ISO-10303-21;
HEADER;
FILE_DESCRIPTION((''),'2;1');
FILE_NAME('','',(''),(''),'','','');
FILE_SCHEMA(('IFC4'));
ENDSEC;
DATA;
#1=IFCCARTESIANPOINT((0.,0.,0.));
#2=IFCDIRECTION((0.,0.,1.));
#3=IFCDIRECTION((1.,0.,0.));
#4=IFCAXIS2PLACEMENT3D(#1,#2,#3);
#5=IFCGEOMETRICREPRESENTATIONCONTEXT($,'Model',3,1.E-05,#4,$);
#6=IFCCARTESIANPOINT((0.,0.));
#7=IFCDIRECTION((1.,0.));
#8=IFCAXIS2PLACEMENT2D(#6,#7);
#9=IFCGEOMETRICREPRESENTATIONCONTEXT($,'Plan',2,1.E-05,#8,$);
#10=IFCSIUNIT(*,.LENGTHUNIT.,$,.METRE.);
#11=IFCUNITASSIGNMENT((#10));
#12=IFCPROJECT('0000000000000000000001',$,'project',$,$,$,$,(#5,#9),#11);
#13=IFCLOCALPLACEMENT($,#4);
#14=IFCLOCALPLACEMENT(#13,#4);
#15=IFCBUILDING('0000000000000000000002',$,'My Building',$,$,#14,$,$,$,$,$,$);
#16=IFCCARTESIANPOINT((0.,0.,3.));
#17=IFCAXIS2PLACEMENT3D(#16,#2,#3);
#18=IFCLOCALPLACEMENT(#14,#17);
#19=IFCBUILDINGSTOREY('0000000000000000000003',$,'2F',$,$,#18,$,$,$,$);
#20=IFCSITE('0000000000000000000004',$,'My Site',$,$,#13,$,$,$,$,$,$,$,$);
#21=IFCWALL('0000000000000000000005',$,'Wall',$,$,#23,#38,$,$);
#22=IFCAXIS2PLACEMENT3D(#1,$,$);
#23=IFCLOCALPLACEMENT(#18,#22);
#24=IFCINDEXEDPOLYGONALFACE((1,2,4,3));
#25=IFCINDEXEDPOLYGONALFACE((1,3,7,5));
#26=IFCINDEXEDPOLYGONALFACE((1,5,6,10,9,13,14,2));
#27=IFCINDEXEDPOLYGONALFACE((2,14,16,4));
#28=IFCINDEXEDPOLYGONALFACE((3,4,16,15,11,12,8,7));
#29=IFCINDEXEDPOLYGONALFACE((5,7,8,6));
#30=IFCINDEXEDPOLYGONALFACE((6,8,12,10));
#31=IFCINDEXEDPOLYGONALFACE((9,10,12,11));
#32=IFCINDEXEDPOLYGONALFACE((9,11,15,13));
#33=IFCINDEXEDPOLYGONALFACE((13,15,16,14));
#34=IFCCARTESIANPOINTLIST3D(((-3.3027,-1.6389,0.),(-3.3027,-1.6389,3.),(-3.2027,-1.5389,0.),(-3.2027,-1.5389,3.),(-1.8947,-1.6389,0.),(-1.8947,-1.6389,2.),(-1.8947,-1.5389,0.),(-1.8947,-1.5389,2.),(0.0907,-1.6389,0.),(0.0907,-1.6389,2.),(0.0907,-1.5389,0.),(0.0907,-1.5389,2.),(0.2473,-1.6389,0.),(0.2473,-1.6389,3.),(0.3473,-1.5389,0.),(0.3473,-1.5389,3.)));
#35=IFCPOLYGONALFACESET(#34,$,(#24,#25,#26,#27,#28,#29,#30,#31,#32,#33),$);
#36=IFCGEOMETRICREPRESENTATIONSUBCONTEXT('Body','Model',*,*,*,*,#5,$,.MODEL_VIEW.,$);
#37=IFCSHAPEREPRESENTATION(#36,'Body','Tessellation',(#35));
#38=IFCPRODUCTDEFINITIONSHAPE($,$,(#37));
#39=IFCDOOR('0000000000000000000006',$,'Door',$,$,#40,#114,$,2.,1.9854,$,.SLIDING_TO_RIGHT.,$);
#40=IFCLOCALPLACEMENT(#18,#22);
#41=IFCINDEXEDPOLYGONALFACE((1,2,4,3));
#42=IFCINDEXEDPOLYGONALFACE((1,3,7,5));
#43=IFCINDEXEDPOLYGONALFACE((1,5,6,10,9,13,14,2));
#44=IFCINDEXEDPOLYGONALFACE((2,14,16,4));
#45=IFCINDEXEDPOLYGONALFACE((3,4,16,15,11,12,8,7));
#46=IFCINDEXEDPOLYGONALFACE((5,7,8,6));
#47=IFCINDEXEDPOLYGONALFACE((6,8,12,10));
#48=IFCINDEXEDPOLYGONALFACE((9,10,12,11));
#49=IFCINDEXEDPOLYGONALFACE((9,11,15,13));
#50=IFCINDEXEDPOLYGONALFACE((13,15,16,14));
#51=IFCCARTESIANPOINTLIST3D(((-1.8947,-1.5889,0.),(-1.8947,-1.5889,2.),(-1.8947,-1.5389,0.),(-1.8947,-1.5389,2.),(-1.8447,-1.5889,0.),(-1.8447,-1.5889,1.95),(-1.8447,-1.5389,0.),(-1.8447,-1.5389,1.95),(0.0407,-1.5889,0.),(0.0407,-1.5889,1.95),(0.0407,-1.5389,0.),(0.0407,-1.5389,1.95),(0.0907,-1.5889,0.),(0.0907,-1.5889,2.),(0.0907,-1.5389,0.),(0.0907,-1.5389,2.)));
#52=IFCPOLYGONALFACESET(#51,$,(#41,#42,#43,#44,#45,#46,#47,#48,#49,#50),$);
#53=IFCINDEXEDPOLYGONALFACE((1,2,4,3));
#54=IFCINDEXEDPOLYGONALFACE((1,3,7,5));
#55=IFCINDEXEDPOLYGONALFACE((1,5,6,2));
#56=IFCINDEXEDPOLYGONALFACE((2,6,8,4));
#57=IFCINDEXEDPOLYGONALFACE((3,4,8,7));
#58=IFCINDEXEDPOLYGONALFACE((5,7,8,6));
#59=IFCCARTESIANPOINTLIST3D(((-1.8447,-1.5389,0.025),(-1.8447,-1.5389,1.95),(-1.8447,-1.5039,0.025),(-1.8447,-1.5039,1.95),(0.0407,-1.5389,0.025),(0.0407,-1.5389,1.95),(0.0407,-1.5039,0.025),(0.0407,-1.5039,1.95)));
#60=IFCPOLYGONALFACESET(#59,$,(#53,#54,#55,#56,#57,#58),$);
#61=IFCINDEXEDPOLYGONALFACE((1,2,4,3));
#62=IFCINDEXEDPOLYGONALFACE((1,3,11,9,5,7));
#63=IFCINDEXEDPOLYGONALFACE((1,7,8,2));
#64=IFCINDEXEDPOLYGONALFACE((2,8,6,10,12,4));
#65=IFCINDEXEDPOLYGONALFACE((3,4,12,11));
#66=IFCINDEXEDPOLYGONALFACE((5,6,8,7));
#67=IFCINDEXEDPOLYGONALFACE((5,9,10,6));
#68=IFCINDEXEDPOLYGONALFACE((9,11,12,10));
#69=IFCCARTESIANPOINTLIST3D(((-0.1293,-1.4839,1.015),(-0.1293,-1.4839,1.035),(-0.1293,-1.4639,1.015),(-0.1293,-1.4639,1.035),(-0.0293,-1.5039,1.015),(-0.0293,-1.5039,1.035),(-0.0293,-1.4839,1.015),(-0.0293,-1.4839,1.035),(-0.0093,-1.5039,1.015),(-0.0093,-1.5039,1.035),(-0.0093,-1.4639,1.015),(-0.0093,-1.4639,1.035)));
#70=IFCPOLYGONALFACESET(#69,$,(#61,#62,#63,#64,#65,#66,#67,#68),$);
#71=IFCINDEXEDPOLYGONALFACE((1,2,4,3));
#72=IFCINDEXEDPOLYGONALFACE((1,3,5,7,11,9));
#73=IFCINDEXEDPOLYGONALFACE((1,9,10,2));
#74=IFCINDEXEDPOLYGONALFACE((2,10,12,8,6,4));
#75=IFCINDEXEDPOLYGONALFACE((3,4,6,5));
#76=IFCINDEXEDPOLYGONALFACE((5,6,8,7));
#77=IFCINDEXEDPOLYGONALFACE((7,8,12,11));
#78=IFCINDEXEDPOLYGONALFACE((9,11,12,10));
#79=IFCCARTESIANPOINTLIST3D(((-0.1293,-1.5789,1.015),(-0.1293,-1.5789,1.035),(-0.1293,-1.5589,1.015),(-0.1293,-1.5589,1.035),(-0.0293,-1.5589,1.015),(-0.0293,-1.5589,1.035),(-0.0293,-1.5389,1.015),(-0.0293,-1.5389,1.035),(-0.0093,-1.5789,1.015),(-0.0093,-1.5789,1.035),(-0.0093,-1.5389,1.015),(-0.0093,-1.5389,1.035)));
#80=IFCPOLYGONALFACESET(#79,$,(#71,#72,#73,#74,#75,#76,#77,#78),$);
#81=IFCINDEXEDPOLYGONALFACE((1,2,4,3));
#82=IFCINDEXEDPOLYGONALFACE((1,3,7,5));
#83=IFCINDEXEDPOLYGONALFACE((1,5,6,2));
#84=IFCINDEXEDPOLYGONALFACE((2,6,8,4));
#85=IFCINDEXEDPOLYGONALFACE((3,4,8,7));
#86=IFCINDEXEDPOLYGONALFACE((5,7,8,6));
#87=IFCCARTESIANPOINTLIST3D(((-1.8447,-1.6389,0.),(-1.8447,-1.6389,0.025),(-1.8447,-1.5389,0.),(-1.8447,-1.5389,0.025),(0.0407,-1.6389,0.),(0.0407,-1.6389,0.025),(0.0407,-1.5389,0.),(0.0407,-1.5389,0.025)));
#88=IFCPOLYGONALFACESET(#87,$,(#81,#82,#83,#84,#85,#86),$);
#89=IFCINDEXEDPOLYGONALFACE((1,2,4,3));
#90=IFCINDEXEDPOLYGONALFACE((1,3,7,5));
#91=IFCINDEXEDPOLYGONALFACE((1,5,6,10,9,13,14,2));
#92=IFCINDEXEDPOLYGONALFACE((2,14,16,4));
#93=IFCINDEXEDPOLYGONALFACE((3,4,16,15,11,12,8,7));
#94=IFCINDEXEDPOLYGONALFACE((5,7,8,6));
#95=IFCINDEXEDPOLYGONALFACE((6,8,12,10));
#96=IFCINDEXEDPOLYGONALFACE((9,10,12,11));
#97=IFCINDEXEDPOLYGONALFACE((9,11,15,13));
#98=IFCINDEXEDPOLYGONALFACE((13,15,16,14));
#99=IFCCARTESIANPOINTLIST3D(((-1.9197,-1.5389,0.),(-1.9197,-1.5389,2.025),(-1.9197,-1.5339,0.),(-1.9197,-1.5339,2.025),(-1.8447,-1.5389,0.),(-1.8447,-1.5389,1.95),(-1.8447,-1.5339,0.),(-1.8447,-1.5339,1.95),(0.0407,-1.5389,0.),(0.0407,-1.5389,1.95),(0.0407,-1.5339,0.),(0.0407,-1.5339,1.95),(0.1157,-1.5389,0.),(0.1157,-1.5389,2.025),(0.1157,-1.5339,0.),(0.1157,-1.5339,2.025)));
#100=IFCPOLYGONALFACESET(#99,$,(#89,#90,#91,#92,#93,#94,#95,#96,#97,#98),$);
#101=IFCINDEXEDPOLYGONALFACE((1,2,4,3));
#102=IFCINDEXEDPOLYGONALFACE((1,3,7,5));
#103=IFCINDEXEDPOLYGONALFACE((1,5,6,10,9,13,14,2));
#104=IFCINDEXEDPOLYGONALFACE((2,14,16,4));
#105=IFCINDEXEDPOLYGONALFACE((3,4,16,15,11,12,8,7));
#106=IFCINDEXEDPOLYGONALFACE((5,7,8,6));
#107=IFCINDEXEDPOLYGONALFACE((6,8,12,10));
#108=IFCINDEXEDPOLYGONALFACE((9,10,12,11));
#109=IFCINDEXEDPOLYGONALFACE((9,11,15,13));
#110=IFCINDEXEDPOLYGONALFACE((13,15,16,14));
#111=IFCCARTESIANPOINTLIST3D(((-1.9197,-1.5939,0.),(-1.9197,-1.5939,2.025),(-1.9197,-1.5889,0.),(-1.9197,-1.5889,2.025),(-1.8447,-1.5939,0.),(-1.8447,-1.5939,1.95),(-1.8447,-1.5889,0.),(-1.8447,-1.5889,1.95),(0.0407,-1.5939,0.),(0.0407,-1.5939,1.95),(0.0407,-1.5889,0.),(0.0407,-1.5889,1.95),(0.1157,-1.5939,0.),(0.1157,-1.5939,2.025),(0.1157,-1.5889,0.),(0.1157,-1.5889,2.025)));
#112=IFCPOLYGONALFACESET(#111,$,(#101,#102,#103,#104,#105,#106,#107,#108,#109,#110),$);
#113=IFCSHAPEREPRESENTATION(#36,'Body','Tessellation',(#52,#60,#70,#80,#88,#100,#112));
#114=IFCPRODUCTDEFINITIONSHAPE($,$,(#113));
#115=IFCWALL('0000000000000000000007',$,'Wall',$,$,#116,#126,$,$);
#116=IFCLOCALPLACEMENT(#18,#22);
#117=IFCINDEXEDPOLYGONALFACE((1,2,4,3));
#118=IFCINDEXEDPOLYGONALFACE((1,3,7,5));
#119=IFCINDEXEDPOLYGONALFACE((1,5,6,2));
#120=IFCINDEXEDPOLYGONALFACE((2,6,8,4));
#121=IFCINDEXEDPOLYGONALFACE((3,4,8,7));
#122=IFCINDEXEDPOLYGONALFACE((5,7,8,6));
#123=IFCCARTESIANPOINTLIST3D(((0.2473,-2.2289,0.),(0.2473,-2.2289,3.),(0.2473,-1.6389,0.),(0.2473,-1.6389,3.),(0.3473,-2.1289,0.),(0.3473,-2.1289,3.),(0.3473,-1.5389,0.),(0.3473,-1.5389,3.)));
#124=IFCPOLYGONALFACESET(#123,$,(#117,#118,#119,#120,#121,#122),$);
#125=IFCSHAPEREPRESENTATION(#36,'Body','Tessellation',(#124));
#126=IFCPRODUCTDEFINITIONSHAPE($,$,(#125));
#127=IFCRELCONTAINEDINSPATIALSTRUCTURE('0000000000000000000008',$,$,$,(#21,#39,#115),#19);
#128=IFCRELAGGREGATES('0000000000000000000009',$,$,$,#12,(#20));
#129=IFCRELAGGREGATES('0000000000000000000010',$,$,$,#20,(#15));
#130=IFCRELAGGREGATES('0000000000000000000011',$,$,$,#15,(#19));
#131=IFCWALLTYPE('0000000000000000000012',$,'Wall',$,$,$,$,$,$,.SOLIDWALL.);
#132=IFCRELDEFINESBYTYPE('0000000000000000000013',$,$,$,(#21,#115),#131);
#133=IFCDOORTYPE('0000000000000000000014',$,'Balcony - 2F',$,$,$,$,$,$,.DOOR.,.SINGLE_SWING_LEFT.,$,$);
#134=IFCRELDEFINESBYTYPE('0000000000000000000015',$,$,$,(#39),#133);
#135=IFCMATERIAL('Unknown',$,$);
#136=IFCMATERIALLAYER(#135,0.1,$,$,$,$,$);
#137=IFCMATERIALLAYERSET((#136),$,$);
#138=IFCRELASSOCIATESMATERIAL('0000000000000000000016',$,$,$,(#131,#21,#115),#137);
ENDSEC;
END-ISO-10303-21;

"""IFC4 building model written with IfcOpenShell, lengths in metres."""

from ifc_helpers import new_model, entity, si_unit, frame, origin_with_axes, origin_2d_with_axis, place, context, subcontext, project, spatial, line, indexed_curve, outline, extrude, shape, source, transform, mapped, material, layer, layer_set, layer_usage, type_object, type_shapes, element, fill, save


model = new_model("IFC4")

# Units and contexts
model_context = context("Model", 3, precision=1e-05, world=origin_with_axes())
plan_context = context("Plan", 2, precision=1e-05, world=origin_2d_with_axis())
body_context_1 = subcontext(model_context, "Body", "Model", "MODEL_VIEW")
body_context_2 = subcontext(plan_context, "Body", "Plan", "PLAN_VIEW")
ifc_project = project(units=[si_unit("LENGTHUNIT", "METRE")], contexts=[model_context, plan_context])

# Site, building, storey
site_placement = place(None, origin_with_axes())
site = spatial("IfcSite", under=ifc_project, at=site_placement, Name="My Site")
building_placement = place(site_placement, origin_with_axes())
building = spatial("IfcBuilding", under=site, at=building_placement, Name="My Building")
storey_placement = place(building_placement, frame((0.0, 0.0, 3.0), z_axis=(0.0, 0.0, 1.0), x_axis=(1.0, 0.0, 0.0)))
storey = spatial("IfcBuildingStorey", under=building, at=storey_placement, Name="2F")

# Shared definitions
ifc_material = material(Name="Unknown")

# Shared definitions
ifc_layer_1 = layer(ifc_material, 0.1)
ifc_layer_set_1 = layer_set([ifc_layer_1])
wall_type_1 = type_object("IfcWallType", Name="Wall", PredefinedType="SOLIDWALL", material=ifc_layer_set_1)

# Wall, opening, door
ifc_layer_usage_1 = layer_usage(ifc_layer_set_1, "AXIS2", "POSITIVE", 0.0)
wall_1_placement = place(storey_placement, frame((-3.3027, -1.6389, 0.0), z_axis=(0.0, 0.0, 1.0), x_axis=(1.0, 0.0, 0.0)))
wall_1 = element("IfcWall", 1, at=wall_1_placement, inside=storey, type_object=wall_type_1, material=ifc_layer_usage_1, Name="Wall", context=body_context_1, shape_type="SweptSolid", body=[
    extrude(outline(indexed_curve([(0.0, 0.0), (0.1, 0.1), (3.65, 0.1), (3.55, 0.0)], segments=[line(1, 2, 3, 4, 1)])), origin_with_axes(), (0.0, 0.0, 1.0), 3.0),
])
shared_shape_1 = source(origin_with_axes(), body_context_1, "Body", "SweptSolid", [
    extrude(outline(indexed_curve([(0.0, 0.0), (1.9854, 0.0), (1.9854, 2.0), (0.0, 2.0)], segments=[line(1, 2, 3, 4, 1)])), frame((0.0, -0.6, 0.0), z_axis=(0.0, -1.0, 0.0), x_axis=(1.0, 0.0, 0.0)), (0.0, 0.0, -1.0), 1.2),
])
opening_1_placement = place(wall_1_placement, frame((3.3934, 0.1, 0.0), z_axis=(0.0, 0.0, 1.0), x_axis=(-1.0, 0.0, 0.0)))
opening_1 = element("IfcOpeningElement", 2, at=opening_1_placement, cuts=wall_1, PredefinedType="OPENING", context=body_context_1, shape_type="MappedRepresentation", body=[
    mapped(shared_shape_1, transform((0.0, 0.0, 0.0), x_axis=(1.0, 0.0, 0.0), y_axis=(0.0, 1.0, 0.0), z_axis=(0.0, 0.0, 1.0), scale=1.0)),
])
door_type_1 = type_object("IfcDoorType", Name="Balcony - 2F", OperationType="SINGLE_SWING_LEFT", PredefinedType="DOOR")
shared_shape_2 = source(origin_with_axes(), body_context_1, "Body", "SweptSolid", [
    extrude(outline(indexed_curve([(0.0, 0.0), (0.0, 2.0), (1.9854, 2.0), (1.9854, 0.0), (1.9354, 0.0), (1.9354, 1.95), (0.05, 1.95), (0.05, 0.0)], segments=[line(1, 2, 3, 4, 5, 6, 7, 8, 1)])), frame((0.0, 0.0, 0.0), z_axis=(0.0, -1.0, 0.0), x_axis=(1.0, 0.0, 0.0)), (0.0, 0.0, -1.0), 0.05),
    extrude(outline(indexed_curve([(0.0, 0.0), (1.8854, 0.0), (1.8854, 0.035), (0.0, 0.035)], segments=[line(1, 2, 3, 4, 1)])), frame((0.05, -0.035, 0.025), z_axis=(0.0, 0.0, 1.0), x_axis=(1.0, 0.0, 0.0)), (0.0, 0.0, 1.0), 1.925),
    extrude(outline(indexed_curve([(0.0, 0.0), (0.0, -0.04), (0.12, -0.04), (0.12, -0.02), (0.02, -0.02), (0.02, 0.0)], segments=[line(1, 2, 3, 4, 5, 6, 1)])), frame((0.1, -0.035, 1.015), z_axis=(0.0, 0.0, 1.0), x_axis=(1.0, 0.0, 0.0)), (0.0, 0.0, 1.0), 0.02),
    extrude(outline(indexed_curve([(0.0, 0.0), (0.0, 0.04), (0.12, 0.04), (0.12, 0.02), (0.02, 0.02), (0.02, 0.0)], segments=[line(1, 2, 3, 4, 5, 6, 1)])), frame((0.1, 0.0, 1.015), z_axis=(0.0, 0.0, 1.0), x_axis=(1.0, 0.0, 0.0)), (0.0, 0.0, 1.0), 0.02),
    extrude(outline(indexed_curve([(0.0, 0.0), (1.8854, 0.0), (1.8854, 0.1), (0.0, 0.1)], segments=[line(1, 2, 3, 4, 1)])), frame((0.05, 0.0, 0.0), z_axis=(0.0, 0.0, 1.0), x_axis=(1.0, 0.0, 0.0)), (0.0, 0.0, 1.0), 0.025),
    extrude(outline(indexed_curve([(0.0, 0.0), (0.0, 2.025), (2.0354, 2.025), (2.0354, 0.0), (1.9604, 0.0), (1.9604, 1.95), (0.075, 1.95), (0.075, 0.0)], segments=[line(1, 2, 3, 4, 5, 6, 7, 8, 1)])), frame((-0.025, -0.005, 0.0), z_axis=(0.0, -1.0, 0.0), x_axis=(1.0, 0.0, 0.0)), (0.0, 0.0, -1.0), 0.005),
    extrude(outline(indexed_curve([(0.0, 0.0), (0.0, 2.025), (2.0354, 2.025), (2.0354, 0.0), (1.9604, 0.0), (1.9604, 1.95), (0.075, 1.95), (0.075, 0.0)], segments=[line(1, 2, 3, 4, 5, 6, 7, 8, 1)])), frame((-0.025, 0.05, 0.0), z_axis=(0.0, -1.0, 0.0), x_axis=(1.0, 0.0, 0.0)), (0.0, 0.0, -1.0), 0.005),
])
shared_shape_3 = source(origin_with_axes(), body_context_2, "Body", "Curve2D", [
    entity("IfcIndexedPolyCurve", entity("IfcCartesianPointList2D", [[0.0, 0.0], [0.05, 0.0], [0.05, 0.05], [0.0, 0.05]]), [entity("IfcLineIndex", [1, 2, 3, 4, 1])]),
    entity("IfcIndexedPolyCurve", entity("IfcCartesianPointList2D", [[1.9854, 0.0], [1.9354, 0.0], [1.9354, 0.05], [1.9854, 0.05]]), [entity("IfcLineIndex", [1, 2, 3, 4, 1])]),
    entity("IfcIndexedPolyCurve", entity("IfcCartesianPointList2D", [[2.8782, -0.035], [0.9927, -0.035], [0.9927, 0.0], [2.8782, 0.0]]), [entity("IfcLineIndex", [1, 2, 3, 4, 1])]),
])
type_shapes(door_type_1, [shared_shape_2, shared_shape_3])
door_1_placement = place(opening_1_placement, frame((0.0, 0.0, 0.0), z_axis=(0.0, 0.0, 1.0), x_axis=(1.0, 0.0, 0.0)))
door_1 = element("IfcDoor", 3, at=door_1_placement, inside=storey, type_object=door_type_1, Name="Door", OperationType="SLIDING_TO_RIGHT", OverallHeight=2.0, OverallWidth=1.9854, shapes=[
    shape(body_context_1, "Body", "MappedRepresentation", [mapped(shared_shape_2, transform((0.0, 0.0, 0.0), x_axis=(1.0, 0.0, 0.0), y_axis=(0.0, 1.0, 0.0), z_axis=(0.0, 0.0, 1.0), scale=1.0))]),
    shape(body_context_2, "Body", "MappedRepresentation", [mapped(shared_shape_3, transform((0.0, 0.0, 0.0), x_axis=(1.0, 0.0, 0.0), y_axis=(0.0, 1.0, 0.0), z_axis=(0.0, 0.0, 1.0), scale=1.0))]),
])
fill(opening_1, door_1)

# Wall
ifc_layer_usage_2 = layer_usage(ifc_layer_set_1, "AXIS2", "POSITIVE", 0.0)
wall_2_placement = place(storey_placement, frame((0.2473, -1.6389, 0.0), z_axis=(0.0, 0.0, 1.0), x_axis=(0.0, -1.0, 0.0)))
element("IfcWall", 4, at=wall_2_placement, inside=storey, type_object=wall_type_1, material=ifc_layer_usage_2, Name="Wall", context=body_context_1, shape_type="SweptSolid", body=[
    extrude(outline(indexed_curve([(0.0, 0.0), (-0.1, 0.1), (0.49, 0.1), (0.59, 0.0)], segments=[line(1, 2, 3, 4, 1)])), origin_with_axes(), (0.0, 0.0, 1.0), 3.0),
])

save(model, "model.ifc")
